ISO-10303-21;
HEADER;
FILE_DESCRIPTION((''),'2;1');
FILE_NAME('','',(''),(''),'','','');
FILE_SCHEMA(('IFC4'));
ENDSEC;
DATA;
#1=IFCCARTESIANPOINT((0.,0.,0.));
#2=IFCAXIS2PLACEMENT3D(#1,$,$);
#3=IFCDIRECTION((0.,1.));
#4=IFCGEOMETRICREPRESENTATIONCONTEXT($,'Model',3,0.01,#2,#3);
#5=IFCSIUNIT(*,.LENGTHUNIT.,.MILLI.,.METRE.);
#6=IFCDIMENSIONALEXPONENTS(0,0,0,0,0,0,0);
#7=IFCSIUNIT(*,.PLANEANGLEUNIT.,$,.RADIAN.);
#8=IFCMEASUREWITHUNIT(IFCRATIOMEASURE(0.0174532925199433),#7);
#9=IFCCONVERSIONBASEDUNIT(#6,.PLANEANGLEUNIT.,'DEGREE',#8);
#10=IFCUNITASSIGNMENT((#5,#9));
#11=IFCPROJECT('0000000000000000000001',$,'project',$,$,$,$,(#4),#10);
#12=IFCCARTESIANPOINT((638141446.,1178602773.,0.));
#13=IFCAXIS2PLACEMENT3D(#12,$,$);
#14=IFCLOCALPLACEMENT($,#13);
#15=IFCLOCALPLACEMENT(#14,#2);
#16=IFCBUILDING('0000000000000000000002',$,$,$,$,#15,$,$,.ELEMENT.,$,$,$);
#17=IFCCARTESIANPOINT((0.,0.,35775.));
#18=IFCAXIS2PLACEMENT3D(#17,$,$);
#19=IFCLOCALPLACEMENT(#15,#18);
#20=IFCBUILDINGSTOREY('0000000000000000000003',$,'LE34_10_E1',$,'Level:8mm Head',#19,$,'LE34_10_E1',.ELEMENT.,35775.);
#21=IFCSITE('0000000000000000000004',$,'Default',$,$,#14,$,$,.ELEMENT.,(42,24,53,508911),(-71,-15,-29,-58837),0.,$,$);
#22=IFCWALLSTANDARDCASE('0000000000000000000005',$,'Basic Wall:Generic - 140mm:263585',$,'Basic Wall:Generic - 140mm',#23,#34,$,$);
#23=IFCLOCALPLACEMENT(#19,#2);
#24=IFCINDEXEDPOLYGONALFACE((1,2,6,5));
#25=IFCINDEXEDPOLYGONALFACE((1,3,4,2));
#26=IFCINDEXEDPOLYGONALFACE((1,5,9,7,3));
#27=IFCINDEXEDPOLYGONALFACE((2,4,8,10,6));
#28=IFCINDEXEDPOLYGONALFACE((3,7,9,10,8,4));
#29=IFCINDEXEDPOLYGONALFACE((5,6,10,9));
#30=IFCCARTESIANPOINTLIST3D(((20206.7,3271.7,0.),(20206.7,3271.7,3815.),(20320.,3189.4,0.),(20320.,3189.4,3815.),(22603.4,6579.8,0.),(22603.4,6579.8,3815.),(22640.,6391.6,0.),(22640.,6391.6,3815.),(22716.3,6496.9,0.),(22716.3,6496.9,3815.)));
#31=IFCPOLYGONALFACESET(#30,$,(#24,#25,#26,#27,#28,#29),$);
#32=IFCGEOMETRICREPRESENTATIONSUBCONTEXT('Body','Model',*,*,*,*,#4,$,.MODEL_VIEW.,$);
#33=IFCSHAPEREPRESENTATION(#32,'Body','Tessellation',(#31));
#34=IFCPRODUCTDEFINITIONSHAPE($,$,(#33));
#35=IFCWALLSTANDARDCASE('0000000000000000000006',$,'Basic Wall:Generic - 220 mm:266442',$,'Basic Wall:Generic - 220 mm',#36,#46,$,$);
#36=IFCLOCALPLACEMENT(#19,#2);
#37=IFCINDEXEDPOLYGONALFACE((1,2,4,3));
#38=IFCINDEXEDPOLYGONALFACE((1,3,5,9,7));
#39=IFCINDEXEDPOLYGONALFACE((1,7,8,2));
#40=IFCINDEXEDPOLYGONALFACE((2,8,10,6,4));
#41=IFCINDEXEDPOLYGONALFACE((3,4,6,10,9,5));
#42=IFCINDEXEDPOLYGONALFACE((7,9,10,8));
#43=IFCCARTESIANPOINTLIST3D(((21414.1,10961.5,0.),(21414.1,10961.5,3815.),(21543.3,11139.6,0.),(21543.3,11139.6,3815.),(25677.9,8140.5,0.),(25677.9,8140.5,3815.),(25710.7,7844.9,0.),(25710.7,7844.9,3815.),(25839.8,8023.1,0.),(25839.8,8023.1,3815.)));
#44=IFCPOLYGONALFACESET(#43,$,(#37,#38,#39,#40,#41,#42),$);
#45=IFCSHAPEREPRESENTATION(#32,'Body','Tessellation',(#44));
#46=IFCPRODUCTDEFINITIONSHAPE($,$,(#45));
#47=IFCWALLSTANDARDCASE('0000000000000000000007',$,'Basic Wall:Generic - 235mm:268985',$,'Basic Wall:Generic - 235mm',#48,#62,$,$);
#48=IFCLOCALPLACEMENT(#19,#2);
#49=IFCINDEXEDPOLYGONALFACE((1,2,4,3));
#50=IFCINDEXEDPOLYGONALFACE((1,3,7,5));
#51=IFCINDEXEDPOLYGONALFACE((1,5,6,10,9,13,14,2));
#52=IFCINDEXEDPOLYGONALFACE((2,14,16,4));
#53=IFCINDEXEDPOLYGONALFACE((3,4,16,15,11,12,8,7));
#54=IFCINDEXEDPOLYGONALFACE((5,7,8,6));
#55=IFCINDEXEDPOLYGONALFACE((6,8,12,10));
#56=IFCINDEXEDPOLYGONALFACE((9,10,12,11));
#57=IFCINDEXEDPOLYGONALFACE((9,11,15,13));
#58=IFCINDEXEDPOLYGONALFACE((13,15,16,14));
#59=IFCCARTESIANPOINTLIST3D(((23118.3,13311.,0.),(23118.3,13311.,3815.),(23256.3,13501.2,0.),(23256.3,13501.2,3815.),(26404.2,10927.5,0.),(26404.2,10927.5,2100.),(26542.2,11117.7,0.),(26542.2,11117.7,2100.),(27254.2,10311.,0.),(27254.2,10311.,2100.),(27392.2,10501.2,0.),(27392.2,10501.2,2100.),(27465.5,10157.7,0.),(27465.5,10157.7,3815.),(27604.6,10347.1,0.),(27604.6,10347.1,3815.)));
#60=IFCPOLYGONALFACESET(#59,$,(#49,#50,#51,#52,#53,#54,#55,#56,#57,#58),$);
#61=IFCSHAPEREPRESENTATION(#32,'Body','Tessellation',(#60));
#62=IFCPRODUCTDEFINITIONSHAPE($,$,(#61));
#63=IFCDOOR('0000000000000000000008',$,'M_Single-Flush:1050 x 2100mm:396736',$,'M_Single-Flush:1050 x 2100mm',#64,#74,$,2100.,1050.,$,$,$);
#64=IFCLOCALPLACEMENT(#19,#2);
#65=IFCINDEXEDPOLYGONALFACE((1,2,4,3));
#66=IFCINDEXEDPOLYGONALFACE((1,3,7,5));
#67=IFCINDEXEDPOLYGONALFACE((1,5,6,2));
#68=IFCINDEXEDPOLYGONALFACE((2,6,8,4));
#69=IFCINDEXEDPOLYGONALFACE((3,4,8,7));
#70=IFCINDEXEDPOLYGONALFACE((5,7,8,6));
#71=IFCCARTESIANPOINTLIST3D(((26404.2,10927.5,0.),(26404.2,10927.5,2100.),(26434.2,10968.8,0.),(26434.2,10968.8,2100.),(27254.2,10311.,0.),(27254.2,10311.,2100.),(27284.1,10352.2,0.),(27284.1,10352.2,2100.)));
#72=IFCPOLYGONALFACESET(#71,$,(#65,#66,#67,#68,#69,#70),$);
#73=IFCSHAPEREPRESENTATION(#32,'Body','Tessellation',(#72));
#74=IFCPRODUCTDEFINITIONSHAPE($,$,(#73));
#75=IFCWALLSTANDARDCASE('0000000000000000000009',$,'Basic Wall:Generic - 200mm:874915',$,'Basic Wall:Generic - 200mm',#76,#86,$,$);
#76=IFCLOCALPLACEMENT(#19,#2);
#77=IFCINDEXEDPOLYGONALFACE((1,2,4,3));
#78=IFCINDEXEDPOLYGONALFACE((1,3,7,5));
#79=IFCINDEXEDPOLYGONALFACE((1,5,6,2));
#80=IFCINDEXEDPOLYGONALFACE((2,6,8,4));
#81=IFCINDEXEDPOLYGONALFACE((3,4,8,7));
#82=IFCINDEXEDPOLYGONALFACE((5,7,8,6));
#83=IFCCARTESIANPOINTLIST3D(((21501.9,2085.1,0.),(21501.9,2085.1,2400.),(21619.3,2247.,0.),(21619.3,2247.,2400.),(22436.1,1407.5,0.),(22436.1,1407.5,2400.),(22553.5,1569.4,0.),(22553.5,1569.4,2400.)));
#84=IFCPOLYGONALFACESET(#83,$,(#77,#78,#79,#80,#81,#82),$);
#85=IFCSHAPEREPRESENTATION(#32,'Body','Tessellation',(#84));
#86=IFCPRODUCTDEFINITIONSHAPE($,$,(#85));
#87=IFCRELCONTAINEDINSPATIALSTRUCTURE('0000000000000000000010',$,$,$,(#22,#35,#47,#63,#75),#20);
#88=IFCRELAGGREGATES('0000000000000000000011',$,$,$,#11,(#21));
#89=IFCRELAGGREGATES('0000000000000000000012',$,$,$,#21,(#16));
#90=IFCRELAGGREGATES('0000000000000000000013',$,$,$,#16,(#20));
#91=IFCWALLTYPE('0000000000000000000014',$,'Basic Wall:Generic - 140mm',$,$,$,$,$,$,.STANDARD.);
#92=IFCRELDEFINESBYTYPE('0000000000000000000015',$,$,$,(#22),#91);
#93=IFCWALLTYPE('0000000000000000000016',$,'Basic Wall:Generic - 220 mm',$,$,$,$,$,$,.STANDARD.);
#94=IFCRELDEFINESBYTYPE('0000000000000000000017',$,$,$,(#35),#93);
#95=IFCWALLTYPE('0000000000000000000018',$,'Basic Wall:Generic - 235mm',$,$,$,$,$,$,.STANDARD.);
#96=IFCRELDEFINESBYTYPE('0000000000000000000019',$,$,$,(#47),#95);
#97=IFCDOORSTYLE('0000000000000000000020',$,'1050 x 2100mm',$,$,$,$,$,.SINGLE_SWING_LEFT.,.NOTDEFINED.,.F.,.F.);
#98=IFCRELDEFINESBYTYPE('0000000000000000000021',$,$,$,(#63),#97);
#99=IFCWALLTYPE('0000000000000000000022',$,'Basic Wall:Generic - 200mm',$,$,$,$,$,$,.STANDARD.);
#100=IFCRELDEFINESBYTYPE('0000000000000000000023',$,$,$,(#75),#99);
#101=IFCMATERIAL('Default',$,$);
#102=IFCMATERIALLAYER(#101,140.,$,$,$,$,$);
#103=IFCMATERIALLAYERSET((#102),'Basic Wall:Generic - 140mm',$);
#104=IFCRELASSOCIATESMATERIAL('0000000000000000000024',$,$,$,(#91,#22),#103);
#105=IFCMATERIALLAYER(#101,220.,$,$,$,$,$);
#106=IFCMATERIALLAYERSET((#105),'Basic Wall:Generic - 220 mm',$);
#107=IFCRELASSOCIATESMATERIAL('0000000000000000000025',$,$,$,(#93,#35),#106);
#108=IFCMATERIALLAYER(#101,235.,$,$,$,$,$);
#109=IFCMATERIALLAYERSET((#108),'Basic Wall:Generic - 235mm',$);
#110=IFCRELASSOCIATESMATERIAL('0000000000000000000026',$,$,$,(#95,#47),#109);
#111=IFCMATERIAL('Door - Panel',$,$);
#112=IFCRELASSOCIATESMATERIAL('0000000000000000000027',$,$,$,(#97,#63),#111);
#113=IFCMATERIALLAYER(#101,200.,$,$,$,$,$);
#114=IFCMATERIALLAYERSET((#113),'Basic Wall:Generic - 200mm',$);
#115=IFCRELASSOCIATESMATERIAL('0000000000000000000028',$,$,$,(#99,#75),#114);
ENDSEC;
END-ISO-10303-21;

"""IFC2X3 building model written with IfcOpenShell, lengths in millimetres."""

from ifc_helpers import new_model, entity, si_unit, converted_unit, direction, frame, frame_2d, origin, place, context, subcontext, project, spatial, polyline, rectangle, outline, extrude, source, transform, mapped, material, layer, layer_set, layer_usage, type_object, type_shapes, element, fill, save


model = new_model("IFC2X3")

# Units and contexts
model_context = context("Model", 3, precision=0.01, world=origin(), true_north=direction((0.0, 1.0)))
body_context = subcontext(model_context, "Body", "Model", "MODEL_VIEW")
ifc_project = project(units=[si_unit("LENGTHUNIT", "METRE", prefix="MILLI"), converted_unit("PLANEANGLEUNIT", "DEGREE", entity("IfcRatioMeasure", 0.0174532925199433), si_unit("PLANEANGLEUNIT", "RADIAN"), dimensions=[0, 0, 0, 0, 0, 0, 0])], contexts=[model_context])

# Site, building, storey
site_placement = place(None, frame((638141446.0, 1178602773.0, 0.0)))
site = spatial("IfcSite", under=ifc_project, at=site_placement, Name="Default", CompositionType="ELEMENT", RefLatitude=(42, 24, 53, 508911), RefLongitude=(-71, -15, -29, -58837), RefElevation=0.0)
building_placement = place(site_placement, origin())
building = spatial("IfcBuilding", under=site, at=building_placement, CompositionType="ELEMENT")
storey_placement = place(building_placement, frame((0.0, 0.0, 35775.0)))
storey = spatial("IfcBuildingStorey", under=building, at=storey_placement, Name="LE34_10_E1", ObjectType="Level:8mm Head", LongName="LE34_10_E1", CompositionType="ELEMENT", Elevation=35775.0)

# Wall
ifc_material_1 = material(Name="Default")
ifc_layer_1 = layer(ifc_material_1, 140.0)
ifc_layer_set_1 = layer_set([ifc_layer_1], Name="Basic Wall:Generic - 140mm")
ifc_layer_usage_1 = layer_usage(ifc_layer_set_1, "AXIS2", "NEGATIVE", 70.0)
wall_type_1 = type_object("IfcWallType", Name="Basic Wall:Generic - 140mm", PredefinedType="STANDARD", material=ifc_layer_set_1)
wall_1_placement = place(storey_placement, frame((20263.3, 3230.5, 0.0), z_axis=(0.0, 0.0, 1.0), x_axis=(0.5867, 0.809804, 0.0)))
element("IfcWallStandardCase", 1, at=wall_1_placement, inside=storey, type_object=wall_type_1, material=ifc_layer_usage_1, Name="Basic Wall:Generic - 140mm:263585", ObjectType="Basic Wall:Generic - 140mm", context=body_context, shape_type="SweptSolid", body=[
    extrude(outline(polyline([(4084.2, -70.0), (4085.2, 70.0), (0.1, 70.0), (0.0, -70.0), (3954.2, -70.0), (4084.2, -70.0)])), origin(), (0.0, 0.0, 1.0), 3815.0),
])

# Wall
ifc_layer_2 = layer(ifc_material_1, 220.0)
ifc_layer_set_2 = layer_set([ifc_layer_2], Name="Basic Wall:Generic - 220 mm")
ifc_layer_usage_2 = layer_usage(ifc_layer_set_2, "AXIS2", "NEGATIVE", 110.0)
wall_type_2 = type_object("IfcWallType", Name="Basic Wall:Generic - 220 mm", PredefinedType="STANDARD", material=ifc_layer_set_2)
wall_2_placement = place(storey_placement, frame((21478.7, 11050.6, 0.0), z_axis=(0.0, 0.0, 1.0), x_axis=(0.809468, -0.587164, 0.0)))
element("IfcWallStandardCase", 2, at=wall_2_placement, inside=storey, type_object=wall_type_2, material=ifc_layer_usage_2, Name="Basic Wall:Generic - 220 mm:266442", ObjectType="Basic Wall:Generic - 220 mm", context=body_context, shape_type="SweptSolid", body=[
    extrude(outline(polyline([(5308.0, -110.0), (5307.8, 110.0), (5107.8, 110.0), (0.0, 110.0), (0.0, -110.0), (5308.0, -110.0)])), origin(), (0.0, 0.0, 1.0), 3815.0),
])

# Wall, opening, door
ifc_layer_3 = layer(ifc_material_1, 235.0)
ifc_layer_set_3 = layer_set([ifc_layer_3], Name="Basic Wall:Generic - 235mm")
ifc_layer_usage_3 = layer_usage(ifc_layer_set_3, "AXIS2", "POSITIVE", -117.5)
wall_type_3 = type_object("IfcWallType", Name="Basic Wall:Generic - 235mm", PredefinedType="STANDARD", material=ifc_layer_set_3)
wall_3_placement = place(storey_placement, frame((23187.3, 13406.1, 0.0), z_axis=(0.0, 0.0, 1.0), x_axis=(0.809468, -0.587164, 0.0)))
wall_3 = element("IfcWallStandardCase", 3, at=wall_3_placement, inside=storey, type_object=wall_type_3, material=ifc_layer_usage_3, Name="Basic Wall:Generic - 235mm:268985", ObjectType="Basic Wall:Generic - 235mm", context=body_context, shape_type="SweptSolid", body=[
    extrude(outline(polyline([(0.0, -117.5), (5370.4, -117.5), (5371.8, 117.5), (3915.3, 117.5), (3785.3, 117.5), (0.0, 117.5), (0.0, -117.5)])), origin(), (0.0, 0.0, 1.0), 3815.0),
])
opening_1_placement = place(wall_3_placement, frame((5109.3, 117.5, 0.0)))
opening_1 = element("IfcOpeningElement", 4, at=opening_1_placement, cuts=wall_3, ObjectType="Opening", context=body_context, shape_type="SweptSolid", body=[
    extrude(rectangle(XDim=1050.0, YDim=2100.0, at=frame_2d((1050.0, 525.0), x_axis=(0.0, -1.0))), frame((0.0, 0.0, 0.0), z_axis=(0.0, -1.0, 0.0), x_axis=(0.0, 0.0, 1.0)), (0.0, 0.0, 1.0), 235.0),
])
ifc_material_2 = material(Name="Door - Panel")
door_style = type_object("IfcDoorStyle", Name="1050 x 2100mm", ConstructionType="NOTDEFINED", OperationType="SINGLE_SWING_LEFT", ParameterTakesPrecedence=False, Sizeable=False, material=ifc_material_2)
shared_shape = source(origin(), body_context, "Body", "SweptSolid", [
    extrude(rectangle(XDim=1050.0, YDim=51.0, at=frame_2d((0.0, 0.0), x_axis=(1.0, 0.0))), frame((525.0, 209.5, 0.0)), (0.0, 0.0, 1.0), 2100.0),
])
type_shapes(door_style, [shared_shape])
door_placement = place(opening_1_placement, frame((0.0, 0.0, 0.0), z_axis=(0.0, 0.0, 1.0), x_axis=(-1.0, 0.0, 0.0)))
door = element("IfcDoor", 5, at=door_placement, inside=storey, type_object=door_style, material=ifc_material_2, Name="M_Single-Flush:1050 x 2100mm:396736", ObjectType="M_Single-Flush:1050 x 2100mm", OverallHeight=2100.0, OverallWidth=1050.0, context=body_context, shape_type="MappedRepresentation", body=[
    mapped(shared_shape, transform((0.0, 0.0, 0.0), scale=1.0)),
])
fill(opening_1, door)

# Shared definitions
ifc_layer_4 = layer(ifc_material_1, 200.0)
ifc_layer_set_4 = layer_set([ifc_layer_4], Name="Basic Wall:Generic - 200mm")
wall_type_4 = type_object("IfcWallType", Name="Basic Wall:Generic - 200mm", PredefinedType="STANDARD", material=ifc_layer_set_4)

# Wall
ifc_layer_usage_4 = layer_usage(ifc_layer_set_4, "AXIS2", "NEGATIVE", 100.0)
wall_4_placement = place(storey_placement, frame((21560.6, 2166.0, 0.0), z_axis=(0.0, 0.0, 1.0), x_axis=(0.809468, -0.587164, 0.0)))
element("IfcWallStandardCase", 6, at=wall_4_placement, inside=storey, type_object=wall_type_4, material=ifc_layer_usage_4, Name="Basic Wall:Generic - 200mm:874915", ObjectType="Basic Wall:Generic - 200mm", context=body_context, shape_type="SweptSolid", body=[
    extrude(rectangle(XDim=1154.0, YDim=200.0, at=frame_2d((577.0, 0.0), x_axis=(-1.0, 0.0))), origin(), (0.0, 0.0, 1.0), 2400.0),
])

save(model, "model.ifc")
